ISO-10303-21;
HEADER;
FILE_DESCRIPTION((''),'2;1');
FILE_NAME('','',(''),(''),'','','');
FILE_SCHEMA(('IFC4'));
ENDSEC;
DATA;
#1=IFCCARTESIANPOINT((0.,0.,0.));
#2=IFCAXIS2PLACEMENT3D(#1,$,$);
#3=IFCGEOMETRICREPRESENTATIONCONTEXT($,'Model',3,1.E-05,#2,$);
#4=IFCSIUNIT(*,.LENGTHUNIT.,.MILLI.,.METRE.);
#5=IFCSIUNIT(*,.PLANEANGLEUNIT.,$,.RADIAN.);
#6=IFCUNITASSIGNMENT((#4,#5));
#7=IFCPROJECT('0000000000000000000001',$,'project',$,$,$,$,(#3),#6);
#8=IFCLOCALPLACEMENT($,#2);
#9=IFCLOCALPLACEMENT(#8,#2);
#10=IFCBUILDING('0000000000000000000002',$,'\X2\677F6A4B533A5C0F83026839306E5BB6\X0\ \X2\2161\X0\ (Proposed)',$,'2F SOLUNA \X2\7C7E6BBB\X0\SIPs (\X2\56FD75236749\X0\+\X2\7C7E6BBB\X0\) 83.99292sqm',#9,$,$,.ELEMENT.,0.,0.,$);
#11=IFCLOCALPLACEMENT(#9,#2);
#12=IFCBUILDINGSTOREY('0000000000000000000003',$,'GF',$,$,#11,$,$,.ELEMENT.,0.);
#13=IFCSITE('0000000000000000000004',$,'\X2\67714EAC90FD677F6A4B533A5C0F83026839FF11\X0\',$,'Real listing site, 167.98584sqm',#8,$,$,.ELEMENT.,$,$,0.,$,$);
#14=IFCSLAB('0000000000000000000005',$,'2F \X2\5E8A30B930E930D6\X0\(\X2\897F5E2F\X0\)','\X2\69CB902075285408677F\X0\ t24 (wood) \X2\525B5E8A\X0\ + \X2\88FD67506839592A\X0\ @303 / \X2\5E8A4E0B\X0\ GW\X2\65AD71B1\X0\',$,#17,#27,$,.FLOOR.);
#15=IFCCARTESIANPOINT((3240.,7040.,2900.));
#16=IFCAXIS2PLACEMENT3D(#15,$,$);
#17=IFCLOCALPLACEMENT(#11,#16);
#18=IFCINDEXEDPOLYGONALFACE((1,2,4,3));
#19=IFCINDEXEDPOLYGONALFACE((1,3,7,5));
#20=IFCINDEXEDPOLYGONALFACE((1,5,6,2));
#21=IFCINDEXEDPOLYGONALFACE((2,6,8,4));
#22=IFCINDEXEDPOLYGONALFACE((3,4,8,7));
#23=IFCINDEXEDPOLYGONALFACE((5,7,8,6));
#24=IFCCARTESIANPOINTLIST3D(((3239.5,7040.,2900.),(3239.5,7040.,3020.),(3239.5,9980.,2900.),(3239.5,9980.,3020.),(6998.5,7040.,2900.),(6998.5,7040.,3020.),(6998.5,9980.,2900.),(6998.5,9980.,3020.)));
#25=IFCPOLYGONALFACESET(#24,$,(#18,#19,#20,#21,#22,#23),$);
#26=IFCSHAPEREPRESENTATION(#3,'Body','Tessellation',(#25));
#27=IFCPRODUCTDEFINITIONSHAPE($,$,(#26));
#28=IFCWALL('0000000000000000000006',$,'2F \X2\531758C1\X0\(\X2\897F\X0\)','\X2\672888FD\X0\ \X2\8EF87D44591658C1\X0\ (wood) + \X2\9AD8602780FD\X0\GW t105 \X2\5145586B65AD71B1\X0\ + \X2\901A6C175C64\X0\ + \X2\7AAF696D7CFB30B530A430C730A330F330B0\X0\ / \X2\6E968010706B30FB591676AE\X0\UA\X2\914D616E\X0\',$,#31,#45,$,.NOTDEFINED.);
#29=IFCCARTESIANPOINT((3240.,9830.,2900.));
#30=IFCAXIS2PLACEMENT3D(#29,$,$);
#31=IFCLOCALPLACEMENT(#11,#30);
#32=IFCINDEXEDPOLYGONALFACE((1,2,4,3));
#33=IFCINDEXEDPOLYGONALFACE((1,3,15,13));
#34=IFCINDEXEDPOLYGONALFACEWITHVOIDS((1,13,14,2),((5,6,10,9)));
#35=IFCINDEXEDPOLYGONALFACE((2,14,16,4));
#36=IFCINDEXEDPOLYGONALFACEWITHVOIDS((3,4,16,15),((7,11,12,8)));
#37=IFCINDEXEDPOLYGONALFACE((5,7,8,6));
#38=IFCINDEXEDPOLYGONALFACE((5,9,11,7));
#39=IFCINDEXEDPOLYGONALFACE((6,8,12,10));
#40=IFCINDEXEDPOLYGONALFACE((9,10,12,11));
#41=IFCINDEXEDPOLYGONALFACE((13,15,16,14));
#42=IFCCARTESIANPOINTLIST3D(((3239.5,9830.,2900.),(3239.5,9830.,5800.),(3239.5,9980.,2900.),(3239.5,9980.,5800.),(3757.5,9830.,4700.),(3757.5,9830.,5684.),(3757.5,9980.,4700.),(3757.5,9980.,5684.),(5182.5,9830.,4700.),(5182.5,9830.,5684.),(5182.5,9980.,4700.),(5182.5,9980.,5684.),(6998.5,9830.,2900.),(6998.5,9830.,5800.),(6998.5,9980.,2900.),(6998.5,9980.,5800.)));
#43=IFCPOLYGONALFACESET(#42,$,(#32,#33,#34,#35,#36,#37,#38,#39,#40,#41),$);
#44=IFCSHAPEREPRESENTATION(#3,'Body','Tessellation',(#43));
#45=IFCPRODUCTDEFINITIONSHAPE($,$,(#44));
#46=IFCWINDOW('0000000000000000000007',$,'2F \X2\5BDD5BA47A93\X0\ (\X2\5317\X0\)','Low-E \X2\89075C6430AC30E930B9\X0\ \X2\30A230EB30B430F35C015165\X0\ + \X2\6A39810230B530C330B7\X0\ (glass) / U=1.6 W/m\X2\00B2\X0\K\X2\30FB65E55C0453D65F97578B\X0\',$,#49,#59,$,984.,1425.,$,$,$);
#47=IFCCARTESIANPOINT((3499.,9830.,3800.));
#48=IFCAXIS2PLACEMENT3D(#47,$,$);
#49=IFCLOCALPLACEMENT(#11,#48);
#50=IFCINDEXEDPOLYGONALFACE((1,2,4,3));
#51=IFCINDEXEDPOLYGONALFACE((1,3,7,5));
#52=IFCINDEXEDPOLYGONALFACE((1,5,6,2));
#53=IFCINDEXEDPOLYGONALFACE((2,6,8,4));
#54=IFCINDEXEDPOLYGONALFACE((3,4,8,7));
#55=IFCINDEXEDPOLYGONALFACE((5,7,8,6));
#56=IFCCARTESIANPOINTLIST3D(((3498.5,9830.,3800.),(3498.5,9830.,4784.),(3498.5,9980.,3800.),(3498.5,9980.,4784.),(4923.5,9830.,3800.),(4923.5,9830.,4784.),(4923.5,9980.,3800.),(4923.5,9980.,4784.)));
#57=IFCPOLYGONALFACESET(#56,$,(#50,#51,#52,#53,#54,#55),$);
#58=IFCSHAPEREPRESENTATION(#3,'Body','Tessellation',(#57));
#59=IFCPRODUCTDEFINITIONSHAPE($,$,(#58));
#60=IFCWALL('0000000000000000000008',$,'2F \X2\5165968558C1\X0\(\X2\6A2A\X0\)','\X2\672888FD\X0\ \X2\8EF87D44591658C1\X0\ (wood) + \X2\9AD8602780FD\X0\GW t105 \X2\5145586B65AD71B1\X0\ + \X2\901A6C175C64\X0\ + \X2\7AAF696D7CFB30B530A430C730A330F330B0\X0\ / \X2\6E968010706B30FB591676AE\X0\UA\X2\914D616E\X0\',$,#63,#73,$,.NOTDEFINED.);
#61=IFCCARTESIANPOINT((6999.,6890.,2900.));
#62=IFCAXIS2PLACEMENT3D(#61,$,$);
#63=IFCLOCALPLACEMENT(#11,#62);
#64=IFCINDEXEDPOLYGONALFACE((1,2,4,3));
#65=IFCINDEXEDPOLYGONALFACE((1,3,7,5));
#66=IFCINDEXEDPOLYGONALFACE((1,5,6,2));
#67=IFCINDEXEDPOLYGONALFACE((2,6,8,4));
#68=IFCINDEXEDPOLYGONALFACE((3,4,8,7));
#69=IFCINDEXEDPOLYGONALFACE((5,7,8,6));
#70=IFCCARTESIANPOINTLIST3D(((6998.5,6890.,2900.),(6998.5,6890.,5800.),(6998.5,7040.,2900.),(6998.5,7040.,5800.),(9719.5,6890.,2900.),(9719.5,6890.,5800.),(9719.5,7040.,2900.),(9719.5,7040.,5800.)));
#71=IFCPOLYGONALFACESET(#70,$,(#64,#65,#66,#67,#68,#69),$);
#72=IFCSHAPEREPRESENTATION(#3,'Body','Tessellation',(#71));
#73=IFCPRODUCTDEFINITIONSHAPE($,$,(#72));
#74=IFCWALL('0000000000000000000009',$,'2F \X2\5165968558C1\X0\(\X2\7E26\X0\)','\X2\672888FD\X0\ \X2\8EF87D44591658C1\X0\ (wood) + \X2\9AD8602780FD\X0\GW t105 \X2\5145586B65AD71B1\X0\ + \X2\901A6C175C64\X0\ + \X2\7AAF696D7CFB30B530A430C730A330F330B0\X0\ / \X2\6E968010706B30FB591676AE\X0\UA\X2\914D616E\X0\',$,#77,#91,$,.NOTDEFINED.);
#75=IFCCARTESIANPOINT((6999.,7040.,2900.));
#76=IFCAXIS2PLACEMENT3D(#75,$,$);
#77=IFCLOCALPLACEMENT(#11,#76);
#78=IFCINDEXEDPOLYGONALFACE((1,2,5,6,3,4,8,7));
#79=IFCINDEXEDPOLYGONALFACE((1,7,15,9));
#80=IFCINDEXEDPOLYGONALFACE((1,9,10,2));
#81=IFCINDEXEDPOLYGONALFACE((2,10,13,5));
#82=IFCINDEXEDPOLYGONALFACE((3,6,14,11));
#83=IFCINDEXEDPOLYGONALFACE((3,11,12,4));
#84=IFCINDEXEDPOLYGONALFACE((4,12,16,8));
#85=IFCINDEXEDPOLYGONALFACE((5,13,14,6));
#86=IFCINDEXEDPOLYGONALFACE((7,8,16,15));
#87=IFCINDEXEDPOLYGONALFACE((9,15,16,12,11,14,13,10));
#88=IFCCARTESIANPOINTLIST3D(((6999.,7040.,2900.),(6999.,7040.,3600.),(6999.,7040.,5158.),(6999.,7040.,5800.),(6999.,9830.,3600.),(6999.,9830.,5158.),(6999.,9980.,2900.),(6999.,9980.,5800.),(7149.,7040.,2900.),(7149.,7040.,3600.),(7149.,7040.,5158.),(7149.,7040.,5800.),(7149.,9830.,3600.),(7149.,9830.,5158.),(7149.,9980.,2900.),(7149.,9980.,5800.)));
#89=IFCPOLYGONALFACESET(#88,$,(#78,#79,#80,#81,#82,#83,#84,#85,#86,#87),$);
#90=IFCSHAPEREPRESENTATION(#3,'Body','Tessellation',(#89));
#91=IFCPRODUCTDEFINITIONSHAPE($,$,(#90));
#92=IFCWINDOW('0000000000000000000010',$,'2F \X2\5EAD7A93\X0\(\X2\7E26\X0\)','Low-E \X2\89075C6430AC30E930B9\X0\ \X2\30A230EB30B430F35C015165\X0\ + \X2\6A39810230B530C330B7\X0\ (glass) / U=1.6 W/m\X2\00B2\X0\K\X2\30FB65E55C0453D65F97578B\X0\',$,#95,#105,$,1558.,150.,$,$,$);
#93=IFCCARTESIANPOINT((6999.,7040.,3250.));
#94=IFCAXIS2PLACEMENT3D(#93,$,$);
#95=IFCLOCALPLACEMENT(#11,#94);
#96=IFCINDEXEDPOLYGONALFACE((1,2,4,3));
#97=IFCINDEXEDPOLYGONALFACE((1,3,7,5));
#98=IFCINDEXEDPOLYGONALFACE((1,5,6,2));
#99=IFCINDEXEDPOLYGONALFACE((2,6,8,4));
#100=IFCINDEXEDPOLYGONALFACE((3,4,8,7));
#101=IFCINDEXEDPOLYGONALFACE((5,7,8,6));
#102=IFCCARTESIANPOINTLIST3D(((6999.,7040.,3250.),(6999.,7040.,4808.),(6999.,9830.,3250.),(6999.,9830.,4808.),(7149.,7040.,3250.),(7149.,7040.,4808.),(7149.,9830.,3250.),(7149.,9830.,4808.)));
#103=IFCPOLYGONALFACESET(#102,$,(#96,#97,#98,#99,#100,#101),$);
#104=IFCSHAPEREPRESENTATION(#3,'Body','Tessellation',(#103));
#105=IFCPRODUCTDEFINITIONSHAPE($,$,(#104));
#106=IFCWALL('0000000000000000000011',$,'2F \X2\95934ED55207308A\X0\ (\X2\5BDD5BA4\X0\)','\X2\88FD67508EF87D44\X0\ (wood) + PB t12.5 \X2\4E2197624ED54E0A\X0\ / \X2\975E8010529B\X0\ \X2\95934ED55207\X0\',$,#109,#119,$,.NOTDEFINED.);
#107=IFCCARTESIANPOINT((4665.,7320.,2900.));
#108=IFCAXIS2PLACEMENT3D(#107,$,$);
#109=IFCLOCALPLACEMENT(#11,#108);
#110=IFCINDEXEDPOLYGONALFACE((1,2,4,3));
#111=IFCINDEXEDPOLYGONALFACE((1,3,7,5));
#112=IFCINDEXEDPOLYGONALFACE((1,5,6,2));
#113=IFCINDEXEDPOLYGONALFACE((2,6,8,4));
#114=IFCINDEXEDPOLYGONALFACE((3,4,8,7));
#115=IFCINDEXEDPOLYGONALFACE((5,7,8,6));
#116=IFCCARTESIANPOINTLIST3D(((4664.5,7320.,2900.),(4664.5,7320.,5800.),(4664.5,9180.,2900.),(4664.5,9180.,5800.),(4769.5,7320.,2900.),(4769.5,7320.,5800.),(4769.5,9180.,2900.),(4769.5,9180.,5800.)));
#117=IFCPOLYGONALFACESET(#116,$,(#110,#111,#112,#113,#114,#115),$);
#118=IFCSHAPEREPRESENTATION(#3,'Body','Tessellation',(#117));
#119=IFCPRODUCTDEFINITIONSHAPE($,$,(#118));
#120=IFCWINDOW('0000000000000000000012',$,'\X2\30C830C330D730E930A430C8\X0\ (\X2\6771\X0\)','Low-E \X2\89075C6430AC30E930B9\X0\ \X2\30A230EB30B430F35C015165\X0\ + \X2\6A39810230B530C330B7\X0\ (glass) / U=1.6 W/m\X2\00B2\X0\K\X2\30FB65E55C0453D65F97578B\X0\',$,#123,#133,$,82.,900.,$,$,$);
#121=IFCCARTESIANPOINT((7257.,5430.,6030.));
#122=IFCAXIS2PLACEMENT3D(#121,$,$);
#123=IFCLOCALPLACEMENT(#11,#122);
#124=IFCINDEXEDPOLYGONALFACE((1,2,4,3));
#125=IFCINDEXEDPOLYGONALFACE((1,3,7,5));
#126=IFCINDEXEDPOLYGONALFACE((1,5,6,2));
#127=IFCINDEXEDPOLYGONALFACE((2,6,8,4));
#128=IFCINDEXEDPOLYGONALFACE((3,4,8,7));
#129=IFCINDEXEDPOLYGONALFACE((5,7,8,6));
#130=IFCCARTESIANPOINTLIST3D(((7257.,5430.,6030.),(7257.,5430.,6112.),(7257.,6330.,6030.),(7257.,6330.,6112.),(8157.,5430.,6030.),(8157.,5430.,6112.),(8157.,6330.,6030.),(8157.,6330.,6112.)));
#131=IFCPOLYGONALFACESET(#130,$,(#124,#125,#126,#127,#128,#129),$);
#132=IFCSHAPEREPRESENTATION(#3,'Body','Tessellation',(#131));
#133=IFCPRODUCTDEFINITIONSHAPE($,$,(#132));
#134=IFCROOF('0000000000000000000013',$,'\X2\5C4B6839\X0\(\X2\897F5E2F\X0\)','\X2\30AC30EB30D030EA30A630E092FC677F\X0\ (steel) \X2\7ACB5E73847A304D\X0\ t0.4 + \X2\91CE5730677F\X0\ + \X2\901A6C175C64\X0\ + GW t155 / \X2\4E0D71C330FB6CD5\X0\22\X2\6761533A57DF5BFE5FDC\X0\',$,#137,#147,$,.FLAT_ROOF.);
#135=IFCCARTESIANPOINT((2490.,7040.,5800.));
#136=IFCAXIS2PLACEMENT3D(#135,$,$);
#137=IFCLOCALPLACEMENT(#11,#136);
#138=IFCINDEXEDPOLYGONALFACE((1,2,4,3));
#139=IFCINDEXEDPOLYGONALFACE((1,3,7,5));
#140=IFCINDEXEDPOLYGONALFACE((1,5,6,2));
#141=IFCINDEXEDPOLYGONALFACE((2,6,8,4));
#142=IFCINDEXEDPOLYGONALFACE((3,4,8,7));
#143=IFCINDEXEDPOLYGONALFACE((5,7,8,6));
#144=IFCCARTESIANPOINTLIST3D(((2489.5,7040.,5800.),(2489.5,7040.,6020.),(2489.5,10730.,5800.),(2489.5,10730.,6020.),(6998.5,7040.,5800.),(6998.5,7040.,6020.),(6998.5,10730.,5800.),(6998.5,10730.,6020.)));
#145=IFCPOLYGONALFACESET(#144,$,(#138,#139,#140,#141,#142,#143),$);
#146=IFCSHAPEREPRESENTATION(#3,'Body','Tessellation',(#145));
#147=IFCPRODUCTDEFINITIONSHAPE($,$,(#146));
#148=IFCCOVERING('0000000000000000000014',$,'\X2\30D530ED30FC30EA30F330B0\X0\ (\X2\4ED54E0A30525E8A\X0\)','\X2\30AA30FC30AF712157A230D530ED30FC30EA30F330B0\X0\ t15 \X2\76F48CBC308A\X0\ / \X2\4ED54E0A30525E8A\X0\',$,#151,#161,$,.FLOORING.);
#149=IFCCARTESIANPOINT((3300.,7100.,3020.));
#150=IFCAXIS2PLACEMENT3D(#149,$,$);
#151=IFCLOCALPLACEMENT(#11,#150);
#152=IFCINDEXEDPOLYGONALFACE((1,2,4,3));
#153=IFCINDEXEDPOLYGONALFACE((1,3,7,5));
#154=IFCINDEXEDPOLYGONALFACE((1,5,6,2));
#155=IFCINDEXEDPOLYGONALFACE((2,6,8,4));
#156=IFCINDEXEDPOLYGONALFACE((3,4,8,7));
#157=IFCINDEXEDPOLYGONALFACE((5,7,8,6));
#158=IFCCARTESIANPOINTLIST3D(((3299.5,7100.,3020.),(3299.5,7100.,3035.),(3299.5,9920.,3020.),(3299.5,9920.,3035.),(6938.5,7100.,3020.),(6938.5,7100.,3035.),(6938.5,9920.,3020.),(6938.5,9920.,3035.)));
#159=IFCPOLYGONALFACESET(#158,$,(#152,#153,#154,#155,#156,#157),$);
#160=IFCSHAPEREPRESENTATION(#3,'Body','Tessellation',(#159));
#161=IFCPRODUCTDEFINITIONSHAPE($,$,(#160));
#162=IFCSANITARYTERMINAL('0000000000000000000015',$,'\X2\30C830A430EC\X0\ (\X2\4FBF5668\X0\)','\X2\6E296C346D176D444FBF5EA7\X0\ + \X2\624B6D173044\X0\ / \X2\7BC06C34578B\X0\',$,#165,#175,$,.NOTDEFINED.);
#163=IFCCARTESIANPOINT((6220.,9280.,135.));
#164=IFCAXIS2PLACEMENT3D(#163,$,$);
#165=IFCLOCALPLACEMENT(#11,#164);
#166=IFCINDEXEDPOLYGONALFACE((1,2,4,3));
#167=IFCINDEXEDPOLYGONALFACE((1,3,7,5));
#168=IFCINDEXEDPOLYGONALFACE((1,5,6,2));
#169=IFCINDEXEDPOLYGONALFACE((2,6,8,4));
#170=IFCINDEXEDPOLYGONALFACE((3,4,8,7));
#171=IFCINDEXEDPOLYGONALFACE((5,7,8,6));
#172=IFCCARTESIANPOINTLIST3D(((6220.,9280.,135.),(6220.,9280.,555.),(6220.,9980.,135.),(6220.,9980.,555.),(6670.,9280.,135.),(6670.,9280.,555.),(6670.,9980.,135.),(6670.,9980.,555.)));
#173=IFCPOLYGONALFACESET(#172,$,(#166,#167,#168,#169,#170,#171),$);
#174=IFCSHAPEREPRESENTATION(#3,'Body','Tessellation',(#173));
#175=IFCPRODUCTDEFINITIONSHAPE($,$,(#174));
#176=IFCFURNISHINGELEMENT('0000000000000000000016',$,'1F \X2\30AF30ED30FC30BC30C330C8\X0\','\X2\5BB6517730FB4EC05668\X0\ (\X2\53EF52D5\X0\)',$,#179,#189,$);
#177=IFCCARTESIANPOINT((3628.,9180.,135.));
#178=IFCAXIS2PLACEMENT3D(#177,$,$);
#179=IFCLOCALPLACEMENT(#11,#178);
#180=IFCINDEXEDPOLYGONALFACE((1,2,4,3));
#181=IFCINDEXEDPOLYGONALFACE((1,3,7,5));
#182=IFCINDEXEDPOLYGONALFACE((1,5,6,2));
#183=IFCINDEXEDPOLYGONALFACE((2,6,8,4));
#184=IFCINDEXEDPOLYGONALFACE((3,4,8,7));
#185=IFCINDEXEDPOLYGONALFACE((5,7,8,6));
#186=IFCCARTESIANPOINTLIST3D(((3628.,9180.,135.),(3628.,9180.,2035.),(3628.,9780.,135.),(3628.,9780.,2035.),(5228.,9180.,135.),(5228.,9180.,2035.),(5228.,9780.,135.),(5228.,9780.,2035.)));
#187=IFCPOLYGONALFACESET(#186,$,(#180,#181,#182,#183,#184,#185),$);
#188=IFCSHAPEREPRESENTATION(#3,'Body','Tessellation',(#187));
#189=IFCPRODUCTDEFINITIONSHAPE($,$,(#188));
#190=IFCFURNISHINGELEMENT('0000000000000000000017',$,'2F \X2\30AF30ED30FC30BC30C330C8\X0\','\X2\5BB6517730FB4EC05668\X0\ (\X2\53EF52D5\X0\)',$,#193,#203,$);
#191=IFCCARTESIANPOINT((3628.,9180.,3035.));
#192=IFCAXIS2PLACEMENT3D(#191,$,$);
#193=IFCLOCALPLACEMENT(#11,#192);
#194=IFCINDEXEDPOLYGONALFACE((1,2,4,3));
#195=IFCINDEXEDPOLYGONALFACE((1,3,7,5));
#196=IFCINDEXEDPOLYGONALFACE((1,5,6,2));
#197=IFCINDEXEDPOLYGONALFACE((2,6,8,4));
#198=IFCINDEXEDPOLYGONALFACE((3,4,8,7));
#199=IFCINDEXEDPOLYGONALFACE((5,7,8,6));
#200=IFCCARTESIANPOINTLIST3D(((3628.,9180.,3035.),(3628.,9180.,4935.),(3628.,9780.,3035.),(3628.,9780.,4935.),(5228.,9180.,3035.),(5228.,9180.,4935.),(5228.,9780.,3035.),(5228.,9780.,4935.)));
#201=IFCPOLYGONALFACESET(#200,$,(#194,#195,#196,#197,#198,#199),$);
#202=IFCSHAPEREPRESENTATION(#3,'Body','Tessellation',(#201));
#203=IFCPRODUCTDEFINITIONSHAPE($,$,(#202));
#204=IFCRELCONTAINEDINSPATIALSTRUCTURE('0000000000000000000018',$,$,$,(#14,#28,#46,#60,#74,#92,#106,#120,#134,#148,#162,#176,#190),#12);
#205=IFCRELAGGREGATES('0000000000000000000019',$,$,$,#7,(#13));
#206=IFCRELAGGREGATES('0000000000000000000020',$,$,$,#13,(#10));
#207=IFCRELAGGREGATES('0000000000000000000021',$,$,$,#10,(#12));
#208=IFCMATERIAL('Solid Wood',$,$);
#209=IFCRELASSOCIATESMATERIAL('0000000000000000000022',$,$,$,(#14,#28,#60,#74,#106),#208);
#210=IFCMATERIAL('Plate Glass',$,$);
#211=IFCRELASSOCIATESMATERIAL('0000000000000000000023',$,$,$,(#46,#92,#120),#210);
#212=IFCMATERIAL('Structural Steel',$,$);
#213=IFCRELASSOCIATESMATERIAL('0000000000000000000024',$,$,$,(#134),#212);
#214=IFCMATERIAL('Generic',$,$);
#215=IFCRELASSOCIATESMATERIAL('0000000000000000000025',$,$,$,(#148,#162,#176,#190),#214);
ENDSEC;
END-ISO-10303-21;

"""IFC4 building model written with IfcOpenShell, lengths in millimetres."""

from ifc_helpers import new_model, si_unit, frame, frame_2d, origin, place, context, project, spatial, rectangle, extrude, material, element, fill, save


model = new_model("IFC4")

# Units and contexts
model_context = context("Model", 3, precision=1e-05, world=origin())
ifc_project = project(units=[si_unit("LENGTHUNIT", "METRE", prefix="MILLI"), si_unit("PLANEANGLEUNIT", "RADIAN")], contexts=[model_context])

# Site, building, storey
site_placement = place(None, origin())
site = spatial("IfcSite", under=ifc_project, at=site_placement, Name="東京都板橋区小茂根１", ObjectType="Real listing site, 167.98584sqm", CompositionType="ELEMENT", RefElevation=0.0)
building_placement = place(site_placement, origin())
building = spatial("IfcBuilding", under=site, at=building_placement, Name="板橋区小茂根の家 Ⅱ (Proposed)", ObjectType="2F SOLUNA 籾殻SIPs (国産杉+籾殻) 83.99292sqm", CompositionType="ELEMENT", ElevationOfRefHeight=0.0, ElevationOfTerrain=0.0)
storey_placement = place(building_placement, origin())
storey = spatial("IfcBuildingStorey", under=building, at=storey_placement, Name="GF", CompositionType="ELEMENT", Elevation=0.0)

# Slab
ifc_material_1 = material(Name="Solid Wood")
slab_placement = place(storey_placement, frame((3240.0, 7040.0, 2900.0)))
element("IfcSlab", 1, at=slab_placement, inside=storey, material=ifc_material_1, Name="2F 床スラブ(西帯)", Description="構造用合板 t24 (wood) 剛床 + 製材根太 @303 / 床下 GW断熱", PredefinedType="FLOOR", context=model_context, shape_type="SweptSolid", body=[
    extrude(rectangle(XDim=3759.0, YDim=2940.0, at=frame_2d((1879.0, 1470.0))), frame((3240.0, 7040.0, 2900.0)), (0.0, 0.0, 1.0), 120.0),
])

# Wall, opening, window
wall_1_placement = place(storey_placement, frame((3240.0, 9830.0, 2900.0)))
wall_1 = element("IfcWall", 2, at=wall_1_placement, inside=storey, material=ifc_material_1, Name="2F 北壁(西)", Description="木製 軸組外壁 (wood) + 高性能GW t105 充填断熱 + 通気層 + 窯業系サイディング / 準耐火・外皮UA配慮", PredefinedType="NOTDEFINED", context=model_context, shape_type="SweptSolid", body=[
    extrude(rectangle(XDim=3759.0, YDim=150.0, at=frame_2d((1879.0, 75.0))), frame((3240.0, 9830.0, 2900.0)), (0.0, 0.0, 1.0), 2900.0),
])
opening_1_placement = place(storey_placement, frame((3499.0, 9830.0, 3800.0)))
opening_1 = element("IfcOpeningElement", 3, at=opening_1_placement, cuts=wall_1, PredefinedType="NOTDEFINED", context=model_context, shape_type="SweptSolid", body=[
    extrude(rectangle(XDim=1425.0, YDim=150.0, at=frame_2d((712.0, 75.0))), frame((3499.0, 9830.0, 3800.0)), (0.0, 0.0, 1.0), 984.0),
])
ifc_material_2 = material(Name="Plate Glass")
window_1_placement = place(storey_placement, frame((3499.0, 9830.0, 3800.0)))
window_1 = element("IfcWindow", 4, at=window_1_placement, inside=storey, material=ifc_material_2, Name="2F 寝室窓 (北)", Description="Low-E 複層ガラス アルゴン封入 + 樹脂サッシ (glass) / U=1.6 W/m²K・日射取得型", OverallHeight=984.0, OverallWidth=1425.0, context=model_context, shape_type="SweptSolid", body=[
    extrude(rectangle(XDim=1425.0, YDim=150.0, at=frame_2d((712.0, 75.0))), frame((3499.0, 9830.0, 3800.0)), (0.0, 0.0, 1.0), 984.0),
])
fill(opening_1, window_1)

# Wall
wall_2_placement = place(storey_placement, frame((6999.0, 6890.0, 2900.0)))
element("IfcWall", 5, at=wall_2_placement, inside=storey, material=ifc_material_1, Name="2F 入隅壁(横)", Description="木製 軸組外壁 (wood) + 高性能GW t105 充填断熱 + 通気層 + 窯業系サイディング / 準耐火・外皮UA配慮", PredefinedType="NOTDEFINED", context=model_context, shape_type="SweptSolid", body=[
    extrude(rectangle(XDim=2721.0, YDim=150.0, at=frame_2d((1360.0, 75.0))), frame((6999.0, 6890.0, 2900.0)), (0.0, 0.0, 1.0), 2900.0),
])

# Wall, opening, window
wall_3_placement = place(storey_placement, frame((6999.0, 7040.0, 2900.0)))
wall_3 = element("IfcWall", 6, at=wall_3_placement, inside=storey, material=ifc_material_1, Name="2F 入隅壁(縦)", Description="木製 軸組外壁 (wood) + 高性能GW t105 充填断熱 + 通気層 + 窯業系サイディング / 準耐火・外皮UA配慮", PredefinedType="NOTDEFINED", context=model_context, shape_type="SweptSolid", body=[
    extrude(rectangle(XDim=150.0, YDim=2940.0, at=frame_2d((75.0, 1470.0))), frame((6999.0, 7040.0, 2900.0)), (0.0, 0.0, 1.0), 2900.0),
])
opening_2_placement = place(storey_placement, frame((6999.0, 7040.0, 3250.0)))
opening_2 = element("IfcOpeningElement", 7, at=opening_2_placement, cuts=wall_3, PredefinedType="NOTDEFINED", context=model_context, shape_type="SweptSolid", body=[
    extrude(rectangle(XDim=150.0, YDim=2790.0, at=frame_2d((75.0, 1395.0))), frame((6999.0, 7040.0, 3250.0)), (0.0, 0.0, 1.0), 1558.0),
])
window_2_placement = place(storey_placement, frame((6999.0, 7040.0, 3250.0)))
window_2 = element("IfcWindow", 8, at=window_2_placement, inside=storey, material=ifc_material_2, Name="2F 庭窓(縦)", Description="Low-E 複層ガラス アルゴン封入 + 樹脂サッシ (glass) / U=1.6 W/m²K・日射取得型", OverallHeight=1558.0, OverallWidth=150.0, context=model_context, shape_type="SweptSolid", body=[
    extrude(rectangle(XDim=150.0, YDim=2790.0, at=frame_2d((75.0, 1395.0))), frame((6999.0, 7040.0, 3250.0)), (0.0, 0.0, 1.0), 1558.0),
])
fill(opening_2, window_2)

# Wall
wall_4_placement = place(storey_placement, frame((4665.0, 7320.0, 2900.0)))
element("IfcWall", 9, at=wall_4_placement, inside=storey, material=ifc_material_1, Name="2F 間仕切り (寝室)", Description="製材軸組 (wood) + PB t12.5 両面仕上 / 非耐力 間仕切", PredefinedType="NOTDEFINED", context=model_context, shape_type="SweptSolid", body=[
    extrude(rectangle(XDim=105.0, YDim=1860.0, at=frame_2d((52.0, 930.0))), frame((4665.0, 7320.0, 2900.0)), (0.0, 0.0, 1.0), 2900.0),
])

# Window
window_3_placement = place(storey_placement, frame((7257.0, 5430.0, 6030.0)))
element("IfcWindow", 10, at=window_3_placement, inside=storey, material=ifc_material_2, Name="トップライト (東)", Description="Low-E 複層ガラス アルゴン封入 + 樹脂サッシ (glass) / U=1.6 W/m²K・日射取得型", OverallHeight=82.0, OverallWidth=900.0, context=model_context, shape_type="SweptSolid", body=[
    extrude(rectangle(XDim=900.0, YDim=900.0, at=frame_2d((450.0, 450.0))), frame((7257.0, 5430.0, 6030.0)), (0.0, 0.0, 1.0), 82.0),
])

# Roof
ifc_material_3 = material(Name="Structural Steel")
for number, where, name in (
    (11, (2490.0, 7040.0, 5800.0), "屋根(西帯)"),
):
    element("IfcRoof", number, at=place(storey_placement, frame(where)), inside=storey, material=ifc_material_3, Name=name, Description="ガルバリウム鋼板 (steel) 立平葺き t0.4 + 野地板 + 通気層 + GW t155 / 不燃・法22条区域対応", PredefinedType="FLAT_ROOF", context=model_context, shape_type="SweptSolid", body=[
        extrude(rectangle(XDim=4509.0, YDim=3690.0, at=frame_2d((2254.0, 1845.0))), frame((2490.0, 7040.0, 5800.0)), (0.0, 0.0, 1.0), 220.0),
    ])

# Covering
ifc_material_4 = material(Name="Generic")
covering_placement = place(storey_placement, frame((3300.0, 7100.0, 3020.0)))
element("IfcCovering", 12, at=covering_placement, inside=storey, material=ifc_material_4, Name="フローリング (仕上げ床)", Description="オーク無垢フローリング t15 直貼り / 仕上げ床", PredefinedType="FLOORING", context=model_context, shape_type="SweptSolid", body=[
    extrude(rectangle(XDim=3639.0, YDim=2820.0, at=frame_2d((1819.0, 1410.0))), frame((3300.0, 7100.0, 3020.0)), (0.0, 0.0, 1.0), 15.0),
])

# Sanitary terminal
sanitary_terminal_placement = place(storey_placement, frame((6220.0, 9280.0, 135.0)))
element("IfcSanitaryTerminal", 13, at=sanitary_terminal_placement, inside=storey, material=ifc_material_4, Name="トイレ (便器)", Description="温水洗浄便座 + 手洗い / 節水型", PredefinedType="NOTDEFINED", context=model_context, shape_type="SweptSolid", body=[
    extrude(rectangle(XDim=450.0, YDim=700.0, at=frame_2d((225.0, 350.0))), frame((6220.0, 9280.0, 135.0)), (0.0, 0.0, 1.0), 420.0),
])

# Furnishing elements
furnishing_1_placement = place(storey_placement, frame((3628.0, 9180.0, 135.0)))
element("IfcFurnishingElement", 14, at=furnishing_1_placement, inside=storey, material=ifc_material_4, Name="1F クローゼット", Description="家具・什器 (可動)", context=model_context, shape_type="SweptSolid", body=[
    extrude(rectangle(XDim=1600.0, YDim=600.0, at=frame_2d((800.0, 300.0))), frame((3628.0, 9180.0, 135.0)), (0.0, 0.0, 1.0), 1900.0),
])
furnishing_2_placement = place(storey_placement, frame((3628.0, 9180.0, 3035.0)))
element("IfcFurnishingElement", 15, at=furnishing_2_placement, inside=storey, material=ifc_material_4, Name="2F クローゼット", Description="家具・什器 (可動)", context=model_context, shape_type="SweptSolid", body=[
    extrude(rectangle(XDim=1600.0, YDim=600.0, at=frame_2d((800.0, 300.0))), frame((3628.0, 9180.0, 3035.0)), (0.0, 0.0, 1.0), 1900.0),
])

save(model, "model.ifc")
